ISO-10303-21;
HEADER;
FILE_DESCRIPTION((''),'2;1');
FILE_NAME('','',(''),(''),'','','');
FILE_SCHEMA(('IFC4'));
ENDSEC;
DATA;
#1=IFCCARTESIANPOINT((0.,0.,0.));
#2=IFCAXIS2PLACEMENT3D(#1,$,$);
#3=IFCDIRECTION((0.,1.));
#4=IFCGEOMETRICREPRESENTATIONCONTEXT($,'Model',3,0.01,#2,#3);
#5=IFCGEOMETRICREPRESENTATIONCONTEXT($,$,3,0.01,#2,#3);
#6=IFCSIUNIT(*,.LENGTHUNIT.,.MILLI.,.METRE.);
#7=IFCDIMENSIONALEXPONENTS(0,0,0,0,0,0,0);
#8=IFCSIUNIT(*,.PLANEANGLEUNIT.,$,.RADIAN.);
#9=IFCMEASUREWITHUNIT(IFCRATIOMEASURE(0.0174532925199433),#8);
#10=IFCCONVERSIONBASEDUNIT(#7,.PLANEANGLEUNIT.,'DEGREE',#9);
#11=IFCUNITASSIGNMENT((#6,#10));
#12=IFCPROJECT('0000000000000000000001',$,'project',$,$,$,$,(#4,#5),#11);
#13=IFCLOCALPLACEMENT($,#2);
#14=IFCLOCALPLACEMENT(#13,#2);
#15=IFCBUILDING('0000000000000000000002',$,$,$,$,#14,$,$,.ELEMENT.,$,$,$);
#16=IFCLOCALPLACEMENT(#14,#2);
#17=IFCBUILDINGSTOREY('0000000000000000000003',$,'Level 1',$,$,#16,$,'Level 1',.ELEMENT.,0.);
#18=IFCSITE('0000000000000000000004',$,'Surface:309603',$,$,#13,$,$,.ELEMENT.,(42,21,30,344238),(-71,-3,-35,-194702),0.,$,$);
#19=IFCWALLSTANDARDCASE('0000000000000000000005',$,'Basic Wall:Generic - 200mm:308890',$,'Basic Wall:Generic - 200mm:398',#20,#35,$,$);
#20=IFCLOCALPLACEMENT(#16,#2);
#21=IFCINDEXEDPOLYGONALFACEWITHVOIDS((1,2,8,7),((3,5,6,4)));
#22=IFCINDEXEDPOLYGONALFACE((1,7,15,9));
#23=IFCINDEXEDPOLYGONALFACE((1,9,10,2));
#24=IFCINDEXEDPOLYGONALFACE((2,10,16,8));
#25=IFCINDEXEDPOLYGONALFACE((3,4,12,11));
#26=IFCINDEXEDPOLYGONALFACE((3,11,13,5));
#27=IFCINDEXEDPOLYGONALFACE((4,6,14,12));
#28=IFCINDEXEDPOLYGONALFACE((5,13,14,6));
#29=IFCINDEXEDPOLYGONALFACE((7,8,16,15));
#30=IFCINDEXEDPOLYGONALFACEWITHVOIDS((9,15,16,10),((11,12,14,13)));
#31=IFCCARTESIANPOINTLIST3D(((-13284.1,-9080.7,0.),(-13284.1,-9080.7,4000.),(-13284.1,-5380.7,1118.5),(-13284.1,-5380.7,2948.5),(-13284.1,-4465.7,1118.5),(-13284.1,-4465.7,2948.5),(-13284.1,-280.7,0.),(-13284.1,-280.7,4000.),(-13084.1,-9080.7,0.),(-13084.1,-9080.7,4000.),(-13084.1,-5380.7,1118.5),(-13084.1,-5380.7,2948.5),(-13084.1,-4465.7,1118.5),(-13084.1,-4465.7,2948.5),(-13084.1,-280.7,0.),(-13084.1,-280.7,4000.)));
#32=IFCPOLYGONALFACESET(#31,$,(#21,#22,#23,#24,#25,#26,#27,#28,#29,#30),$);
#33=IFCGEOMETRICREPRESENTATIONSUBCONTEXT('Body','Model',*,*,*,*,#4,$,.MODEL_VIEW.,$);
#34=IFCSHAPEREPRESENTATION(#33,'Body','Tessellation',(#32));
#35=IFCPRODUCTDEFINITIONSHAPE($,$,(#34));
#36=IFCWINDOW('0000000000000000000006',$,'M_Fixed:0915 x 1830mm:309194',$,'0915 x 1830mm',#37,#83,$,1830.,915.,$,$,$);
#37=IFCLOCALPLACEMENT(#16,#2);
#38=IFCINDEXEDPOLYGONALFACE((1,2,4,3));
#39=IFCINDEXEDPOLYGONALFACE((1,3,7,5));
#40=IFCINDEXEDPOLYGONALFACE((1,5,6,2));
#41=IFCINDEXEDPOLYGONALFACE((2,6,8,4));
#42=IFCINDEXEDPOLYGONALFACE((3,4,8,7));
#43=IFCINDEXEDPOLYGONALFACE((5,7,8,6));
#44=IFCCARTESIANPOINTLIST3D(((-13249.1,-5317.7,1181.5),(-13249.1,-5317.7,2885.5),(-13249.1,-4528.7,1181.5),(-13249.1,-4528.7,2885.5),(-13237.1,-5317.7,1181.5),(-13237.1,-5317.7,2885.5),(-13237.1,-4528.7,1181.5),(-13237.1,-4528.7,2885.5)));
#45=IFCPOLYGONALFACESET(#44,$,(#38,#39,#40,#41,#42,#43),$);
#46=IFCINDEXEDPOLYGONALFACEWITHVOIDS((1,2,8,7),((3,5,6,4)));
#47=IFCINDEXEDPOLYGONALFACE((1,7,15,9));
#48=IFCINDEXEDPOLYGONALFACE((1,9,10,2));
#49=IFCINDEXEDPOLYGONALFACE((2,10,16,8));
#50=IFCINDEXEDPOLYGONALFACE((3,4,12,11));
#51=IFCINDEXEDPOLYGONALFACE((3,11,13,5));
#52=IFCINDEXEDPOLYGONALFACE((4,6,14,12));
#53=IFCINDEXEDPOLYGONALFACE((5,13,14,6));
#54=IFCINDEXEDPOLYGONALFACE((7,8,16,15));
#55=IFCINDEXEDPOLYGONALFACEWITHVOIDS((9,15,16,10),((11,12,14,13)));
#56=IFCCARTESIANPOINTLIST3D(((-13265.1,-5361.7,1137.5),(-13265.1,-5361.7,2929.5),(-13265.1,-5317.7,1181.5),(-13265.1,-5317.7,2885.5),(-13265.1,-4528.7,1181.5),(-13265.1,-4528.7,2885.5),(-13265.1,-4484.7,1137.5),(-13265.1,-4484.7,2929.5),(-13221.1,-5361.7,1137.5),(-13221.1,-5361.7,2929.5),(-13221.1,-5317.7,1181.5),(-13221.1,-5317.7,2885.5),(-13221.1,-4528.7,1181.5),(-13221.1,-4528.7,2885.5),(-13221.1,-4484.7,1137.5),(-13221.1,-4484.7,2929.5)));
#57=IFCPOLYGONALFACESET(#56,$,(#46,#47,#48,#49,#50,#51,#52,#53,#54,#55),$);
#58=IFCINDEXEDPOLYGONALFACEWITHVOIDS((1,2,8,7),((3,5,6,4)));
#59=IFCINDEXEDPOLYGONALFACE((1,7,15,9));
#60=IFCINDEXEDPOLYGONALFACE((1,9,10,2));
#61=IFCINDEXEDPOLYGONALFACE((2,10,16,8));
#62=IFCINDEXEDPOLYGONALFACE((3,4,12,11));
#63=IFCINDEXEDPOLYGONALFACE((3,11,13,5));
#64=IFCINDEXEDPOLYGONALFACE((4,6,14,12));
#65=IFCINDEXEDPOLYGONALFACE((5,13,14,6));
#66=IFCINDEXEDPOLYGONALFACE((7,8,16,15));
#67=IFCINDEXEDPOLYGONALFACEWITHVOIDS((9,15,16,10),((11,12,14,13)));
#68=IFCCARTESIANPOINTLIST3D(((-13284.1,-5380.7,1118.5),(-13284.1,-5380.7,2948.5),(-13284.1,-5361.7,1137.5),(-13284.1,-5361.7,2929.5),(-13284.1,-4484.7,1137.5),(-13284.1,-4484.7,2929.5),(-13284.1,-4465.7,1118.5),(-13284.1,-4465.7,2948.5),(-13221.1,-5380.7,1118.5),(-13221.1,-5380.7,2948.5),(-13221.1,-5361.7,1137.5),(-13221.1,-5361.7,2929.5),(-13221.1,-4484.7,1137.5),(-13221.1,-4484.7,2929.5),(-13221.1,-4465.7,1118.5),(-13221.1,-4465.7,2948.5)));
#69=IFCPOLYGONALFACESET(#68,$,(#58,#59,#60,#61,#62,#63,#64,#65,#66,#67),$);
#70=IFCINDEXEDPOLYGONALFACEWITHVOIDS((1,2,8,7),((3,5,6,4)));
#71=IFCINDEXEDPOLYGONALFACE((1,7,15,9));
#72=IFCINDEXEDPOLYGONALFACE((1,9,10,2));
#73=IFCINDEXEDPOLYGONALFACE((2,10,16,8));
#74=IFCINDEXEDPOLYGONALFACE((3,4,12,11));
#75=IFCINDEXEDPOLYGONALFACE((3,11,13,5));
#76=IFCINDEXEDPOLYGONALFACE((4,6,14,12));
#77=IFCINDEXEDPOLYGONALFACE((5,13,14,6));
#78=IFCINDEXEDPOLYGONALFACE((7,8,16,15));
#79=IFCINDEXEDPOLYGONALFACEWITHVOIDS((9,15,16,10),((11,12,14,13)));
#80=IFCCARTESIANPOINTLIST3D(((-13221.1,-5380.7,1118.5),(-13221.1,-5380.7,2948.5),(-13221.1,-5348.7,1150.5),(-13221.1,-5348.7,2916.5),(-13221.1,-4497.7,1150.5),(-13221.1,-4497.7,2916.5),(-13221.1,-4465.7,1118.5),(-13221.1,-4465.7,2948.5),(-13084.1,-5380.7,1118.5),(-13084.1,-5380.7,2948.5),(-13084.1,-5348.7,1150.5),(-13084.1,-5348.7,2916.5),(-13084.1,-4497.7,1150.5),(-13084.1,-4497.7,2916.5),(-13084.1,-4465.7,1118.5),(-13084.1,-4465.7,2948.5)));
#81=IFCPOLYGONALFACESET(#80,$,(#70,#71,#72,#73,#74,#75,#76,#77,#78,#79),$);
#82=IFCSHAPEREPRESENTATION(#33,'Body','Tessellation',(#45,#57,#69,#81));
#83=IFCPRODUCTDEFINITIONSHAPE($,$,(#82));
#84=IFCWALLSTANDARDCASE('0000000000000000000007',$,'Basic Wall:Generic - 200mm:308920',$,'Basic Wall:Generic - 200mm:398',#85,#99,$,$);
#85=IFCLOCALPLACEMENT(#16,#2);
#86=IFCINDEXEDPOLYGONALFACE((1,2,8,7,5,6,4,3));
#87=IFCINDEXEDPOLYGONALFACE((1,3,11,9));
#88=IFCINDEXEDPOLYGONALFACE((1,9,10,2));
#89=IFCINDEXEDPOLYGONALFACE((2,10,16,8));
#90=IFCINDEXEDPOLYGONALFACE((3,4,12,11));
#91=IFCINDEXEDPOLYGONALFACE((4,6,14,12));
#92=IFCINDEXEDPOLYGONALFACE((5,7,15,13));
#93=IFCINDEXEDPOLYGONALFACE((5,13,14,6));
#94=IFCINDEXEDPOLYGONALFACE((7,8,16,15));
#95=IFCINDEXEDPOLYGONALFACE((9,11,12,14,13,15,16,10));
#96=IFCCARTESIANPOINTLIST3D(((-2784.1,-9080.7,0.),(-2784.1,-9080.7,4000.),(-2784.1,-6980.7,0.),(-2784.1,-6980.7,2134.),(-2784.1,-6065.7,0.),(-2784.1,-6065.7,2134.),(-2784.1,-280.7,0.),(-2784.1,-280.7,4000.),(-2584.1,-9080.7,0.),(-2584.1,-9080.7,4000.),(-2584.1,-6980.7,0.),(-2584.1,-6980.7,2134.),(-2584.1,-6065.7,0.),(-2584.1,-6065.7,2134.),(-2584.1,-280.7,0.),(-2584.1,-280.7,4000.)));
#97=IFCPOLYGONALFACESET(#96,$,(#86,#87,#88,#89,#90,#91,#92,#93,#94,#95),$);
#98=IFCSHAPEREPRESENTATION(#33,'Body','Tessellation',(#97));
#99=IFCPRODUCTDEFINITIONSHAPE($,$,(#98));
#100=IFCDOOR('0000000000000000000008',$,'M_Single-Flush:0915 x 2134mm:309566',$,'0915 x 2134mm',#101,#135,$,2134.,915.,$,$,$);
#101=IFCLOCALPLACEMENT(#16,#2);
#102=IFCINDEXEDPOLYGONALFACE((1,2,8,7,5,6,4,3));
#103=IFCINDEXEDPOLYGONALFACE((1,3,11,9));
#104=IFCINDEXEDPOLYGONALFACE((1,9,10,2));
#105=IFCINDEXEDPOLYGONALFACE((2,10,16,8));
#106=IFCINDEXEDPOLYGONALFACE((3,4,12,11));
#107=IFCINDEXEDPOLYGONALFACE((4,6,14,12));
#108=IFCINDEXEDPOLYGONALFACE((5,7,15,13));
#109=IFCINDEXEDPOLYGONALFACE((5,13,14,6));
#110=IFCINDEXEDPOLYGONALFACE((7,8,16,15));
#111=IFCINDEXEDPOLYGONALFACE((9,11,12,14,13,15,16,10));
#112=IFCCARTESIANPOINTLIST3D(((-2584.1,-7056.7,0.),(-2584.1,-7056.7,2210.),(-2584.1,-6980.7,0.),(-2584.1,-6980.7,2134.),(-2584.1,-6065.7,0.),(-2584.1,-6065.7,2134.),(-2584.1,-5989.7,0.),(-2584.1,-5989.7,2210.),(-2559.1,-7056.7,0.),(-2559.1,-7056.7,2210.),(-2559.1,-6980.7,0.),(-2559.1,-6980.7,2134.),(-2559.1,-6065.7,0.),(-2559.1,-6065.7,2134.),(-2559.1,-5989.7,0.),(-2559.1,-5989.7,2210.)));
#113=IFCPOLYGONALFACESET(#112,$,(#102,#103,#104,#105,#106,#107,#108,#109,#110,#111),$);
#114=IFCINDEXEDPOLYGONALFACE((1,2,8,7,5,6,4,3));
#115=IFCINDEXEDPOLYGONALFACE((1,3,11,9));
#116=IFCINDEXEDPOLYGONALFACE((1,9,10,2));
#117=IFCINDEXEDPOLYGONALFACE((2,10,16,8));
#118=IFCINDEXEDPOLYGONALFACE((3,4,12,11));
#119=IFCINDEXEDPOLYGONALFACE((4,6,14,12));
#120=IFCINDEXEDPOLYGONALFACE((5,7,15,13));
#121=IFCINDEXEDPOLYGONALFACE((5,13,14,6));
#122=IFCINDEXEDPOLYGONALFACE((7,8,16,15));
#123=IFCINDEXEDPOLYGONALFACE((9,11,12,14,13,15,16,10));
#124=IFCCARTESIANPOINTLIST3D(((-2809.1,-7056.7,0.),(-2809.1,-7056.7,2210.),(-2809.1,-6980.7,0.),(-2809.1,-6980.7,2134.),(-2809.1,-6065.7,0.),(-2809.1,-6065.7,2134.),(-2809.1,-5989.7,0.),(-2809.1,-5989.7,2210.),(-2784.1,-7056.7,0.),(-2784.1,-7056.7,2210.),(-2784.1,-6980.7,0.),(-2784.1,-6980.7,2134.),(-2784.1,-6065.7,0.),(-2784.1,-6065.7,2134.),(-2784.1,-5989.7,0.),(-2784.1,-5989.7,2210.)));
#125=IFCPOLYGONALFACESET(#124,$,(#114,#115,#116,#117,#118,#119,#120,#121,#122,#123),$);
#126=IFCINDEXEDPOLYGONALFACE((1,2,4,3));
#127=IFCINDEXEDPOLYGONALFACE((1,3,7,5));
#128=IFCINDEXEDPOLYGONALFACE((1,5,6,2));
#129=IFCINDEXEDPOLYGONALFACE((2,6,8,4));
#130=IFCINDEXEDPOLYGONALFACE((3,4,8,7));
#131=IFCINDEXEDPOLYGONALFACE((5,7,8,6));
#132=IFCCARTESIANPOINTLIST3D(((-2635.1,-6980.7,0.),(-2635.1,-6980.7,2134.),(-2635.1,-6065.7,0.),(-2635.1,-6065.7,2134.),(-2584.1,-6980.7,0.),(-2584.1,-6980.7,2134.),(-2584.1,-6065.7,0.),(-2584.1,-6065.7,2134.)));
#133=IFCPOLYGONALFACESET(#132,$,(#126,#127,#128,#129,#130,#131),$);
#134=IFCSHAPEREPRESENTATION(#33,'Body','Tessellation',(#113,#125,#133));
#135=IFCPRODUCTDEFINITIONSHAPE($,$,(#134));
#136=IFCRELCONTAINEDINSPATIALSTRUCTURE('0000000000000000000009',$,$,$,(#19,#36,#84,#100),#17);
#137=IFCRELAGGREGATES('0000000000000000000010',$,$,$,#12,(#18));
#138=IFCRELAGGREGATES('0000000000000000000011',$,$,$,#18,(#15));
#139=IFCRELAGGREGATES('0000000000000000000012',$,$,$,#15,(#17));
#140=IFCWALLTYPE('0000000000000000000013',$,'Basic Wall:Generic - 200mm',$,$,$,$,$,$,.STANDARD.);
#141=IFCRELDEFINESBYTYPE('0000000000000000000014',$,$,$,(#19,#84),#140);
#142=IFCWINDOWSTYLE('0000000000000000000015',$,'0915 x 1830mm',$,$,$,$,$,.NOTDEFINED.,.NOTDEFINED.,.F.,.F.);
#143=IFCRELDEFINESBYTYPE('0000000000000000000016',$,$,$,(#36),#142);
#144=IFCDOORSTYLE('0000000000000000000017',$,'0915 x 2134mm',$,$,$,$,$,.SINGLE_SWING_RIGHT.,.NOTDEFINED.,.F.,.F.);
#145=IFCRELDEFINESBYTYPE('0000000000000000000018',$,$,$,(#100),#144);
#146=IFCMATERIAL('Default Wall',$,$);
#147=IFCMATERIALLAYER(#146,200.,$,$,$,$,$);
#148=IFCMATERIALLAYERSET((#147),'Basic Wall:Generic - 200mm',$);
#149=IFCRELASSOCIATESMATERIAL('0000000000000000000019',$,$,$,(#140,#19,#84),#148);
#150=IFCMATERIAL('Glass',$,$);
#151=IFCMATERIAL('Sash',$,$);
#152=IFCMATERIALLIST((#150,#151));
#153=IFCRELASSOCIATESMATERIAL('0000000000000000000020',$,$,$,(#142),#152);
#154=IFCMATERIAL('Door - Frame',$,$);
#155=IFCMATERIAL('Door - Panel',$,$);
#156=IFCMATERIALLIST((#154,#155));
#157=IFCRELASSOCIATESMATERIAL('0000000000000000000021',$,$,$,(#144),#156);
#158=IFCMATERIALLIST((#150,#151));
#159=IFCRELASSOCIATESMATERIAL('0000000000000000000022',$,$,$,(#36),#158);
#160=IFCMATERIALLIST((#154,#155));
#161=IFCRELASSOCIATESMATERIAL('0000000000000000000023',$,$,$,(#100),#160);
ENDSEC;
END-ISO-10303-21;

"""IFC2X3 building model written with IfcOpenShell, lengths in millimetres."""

from ifc_helpers import new_model, entity, si_unit, converted_unit, direction, frame, frame_2d, origin, place, context, subcontext, project, spatial, polyline, rectangle, outline, extrude, source, transform, mapped, material, material_list, layer, layer_set, layer_usage, type_object, type_shapes, element, fill, save


model = new_model("IFC2X3")

# Units and contexts
model_context = context("Model", 3, precision=0.01, world=origin(), true_north=direction((0.0, 1.0)))
context_of_model = context(None, 3, precision=0.01, world=origin(), true_north=direction((0.0, 1.0)))
body_context = subcontext(model_context, "Body", "Model", "MODEL_VIEW")
ifc_project = project(units=[si_unit("LENGTHUNIT", "METRE", prefix="MILLI"), converted_unit("PLANEANGLEUNIT", "DEGREE", entity("IfcRatioMeasure", 0.0174532925199433), si_unit("PLANEANGLEUNIT", "RADIAN"), dimensions=[0, 0, 0, 0, 0, 0, 0])], contexts=[model_context, context_of_model])

# Site, building, storey
site_placement = place(None, origin())
site = spatial("IfcSite", under=ifc_project, at=site_placement, Name="Surface:309603", CompositionType="ELEMENT", RefLatitude=(42, 21, 30, 344238), RefLongitude=(-71, -3, -35, -194702), RefElevation=0.0)
building_placement = place(site_placement, origin())
building = spatial("IfcBuilding", under=site, at=building_placement, CompositionType="ELEMENT")
storey_placement = place(building_placement, origin())
storey = spatial("IfcBuildingStorey", under=building, at=storey_placement, Name="Level 1", LongName="Level 1", CompositionType="ELEMENT", Elevation=0.0)

# Shared definitions
ifc_material_1 = material(Name="Default Wall")
ifc_layer_1 = layer(ifc_material_1, 200.0)
ifc_layer_set_1 = layer_set([ifc_layer_1], Name="Basic Wall:Generic - 200mm")
wall_type = type_object("IfcWallType", Name="Basic Wall:Generic - 200mm", PredefinedType="STANDARD", material=ifc_layer_set_1)
ifc_material_2 = material(Name="Glass")
ifc_material_3 = material(Name="Sash")
ifc_material_list_1 = material_list([ifc_material_2, ifc_material_3])
window_style = type_object("IfcWindowStyle", Name="0915 x 1830mm", ConstructionType="NOTDEFINED", OperationType="NOTDEFINED", ParameterTakesPrecedence=False, Sizeable=False, material=ifc_material_list_1)
shared_shape_1 = source(origin(), body_context, "Body", "SweptSolid", [
    extrude(rectangle(XDim=12.0, YDim=789.0, at=frame_2d((0.0, 0.0), x_axis=(1.0, 0.0))), frame((457.5, 159.0, 63.0), z_axis=(0.0, 0.0, 1.0), x_axis=(0.0, -1.0, 0.0)), (0.0, 0.0, 1.0), 1704.0),
    extrude(outline(polyline([(-438.5, -896.0), (438.5, -896.0), (438.5, 896.0), (-438.5, 896.0), (-438.5, -896.0)]), holes=[polyline([(-394.5, -852.0), (-394.5, 852.0), (394.5, 852.0), (394.5, -852.0), (-394.5, -852.0)])]), frame((457.5, 137.0, 915.0), z_axis=(0.0, 1.0, 0.0), x_axis=(1.0, 0.0, 0.0)), (0.0, 0.0, 1.0), 44.0),
    extrude(outline(polyline([(-457.5, -915.0), (457.5, -915.0), (457.5, 915.0), (-457.5, 915.0), (-457.5, -915.0)]), holes=[polyline([(-438.5, -896.0), (-438.5, 896.0), (438.5, 896.0), (438.5, -896.0), (-438.5, -896.0)])]), frame((457.5, 137.0, 915.0), z_axis=(0.0, 1.0, 0.0), x_axis=(1.0, 0.0, 0.0)), (0.0, 0.0, 1.0), 63.0),
    extrude(outline(polyline([(-457.5, -915.0), (457.5, -915.0), (457.5, 915.0), (-457.5, 915.0), (-457.5, -915.0)]), holes=[polyline([(-425.5, -883.0), (-425.5, 883.0), (425.5, 883.0), (425.5, -883.0), (-425.5, -883.0)])]), frame((457.5, 0.0, 915.0), z_axis=(0.0, 1.0, 0.0), x_axis=(1.0, 0.0, 0.0)), (0.0, 0.0, 1.0), 137.0),
])
type_shapes(window_style, [shared_shape_1])

# Shared definitions
ifc_material_4 = material(Name="Door - Frame")
ifc_material_5 = material(Name="Door - Panel")
ifc_material_list_2 = material_list([ifc_material_4, ifc_material_5])
door_style = type_object("IfcDoorStyle", Name="0915 x 2134mm", ConstructionType="NOTDEFINED", OperationType="SINGLE_SWING_RIGHT", ParameterTakesPrecedence=False, Sizeable=False, material=ifc_material_list_2)
shared_shape_2 = source(origin(), body_context, "Body", "SweptSolid", [
    extrude(outline(polyline([(-533.5, -1124.0), (533.5, -1124.0), (533.5, 1086.0), (457.5, 1086.0), (457.5, -1048.0), (-457.5, -1048.0), (-457.5, 1086.0), (-533.5, 1086.0), (-533.5, -1124.0)])), frame((457.5, 200.0, 1086.0), z_axis=(0.0, 1.0, 0.0), x_axis=(1.0, 0.0, 0.0)), (0.0, 0.0, 1.0), 25.0),
    extrude(outline(polyline([(-1124.0, -533.5), (1086.0, -533.5), (1086.0, -457.5), (-1048.0, -457.5), (-1048.0, 457.5), (1086.0, 457.5), (1086.0, 533.5), (-1124.0, 533.5), (-1124.0, -533.5)])), frame((457.5, -25.0, 1086.0), z_axis=(0.0, 1.0, 0.0), x_axis=(0.0, 0.0, -1.0)), (0.0, 0.0, 1.0), 25.0),
    extrude(rectangle(XDim=51.0, YDim=915.0, at=frame_2d((0.0, 0.0), x_axis=(1.0, 0.0))), frame((457.5, 174.5, 0.0), z_axis=(0.0, 0.0, 1.0), x_axis=(0.0, 1.0, 0.0)), (0.0, 0.0, 1.0), 2134.0),
])
type_shapes(door_style, [shared_shape_2])

# Wall, opening, window
ifc_layer_usage_1 = layer_usage(ifc_layer_set_1, "AXIS2", "NEGATIVE", 100.0)
wall_1_placement = place(storey_placement, frame((-13184.1, -280.7, 0.0), z_axis=(0.0, 0.0, 1.0), x_axis=(0.0, -1.0, 0.0)))
wall_1 = element("IfcWallStandardCase", 1, at=wall_1_placement, inside=storey, type_object=wall_type, material=ifc_layer_usage_1, Name="Basic Wall:Generic - 200mm:308890", ObjectType="Basic Wall:Generic - 200mm:398", context=body_context, shape_type="SweptSolid", body=[
    extrude(rectangle(XDim=8800.0, YDim=200.0, at=frame_2d((4400.0, 0.0), x_axis=(-1.0, 0.0))), origin(), (0.0, 0.0, 1.0), 4000.0),
])
opening_1_placement = place(wall_1_placement, frame((5100.0, 100.0, 1118.5)))
opening_1 = element("IfcOpeningElement", 2, at=opening_1_placement, cuts=wall_1, ObjectType="Opening", context=body_context, shape_type="SweptSolid", body=[
    extrude(rectangle(XDim=1830.0, YDim=915.0, at=frame_2d((915.0, 457.5), x_axis=(1.0, 0.0))), frame((0.0, 0.0, 0.0), z_axis=(0.0, -1.0, 0.0), x_axis=(0.0, 0.0, 1.0)), (0.0, 0.0, 1.0), 200.0),
])
ifc_material_list_3 = material_list([ifc_material_2, ifc_material_3])
window_1_placement = place(opening_1_placement, frame((0.0, 0.0, 0.0), z_axis=(0.0, 0.0, 1.0), x_axis=(-1.0, 0.0, 0.0)))
window_1 = element("IfcWindow", 3, at=window_1_placement, inside=storey, type_object=window_style, material=ifc_material_list_3, Name="M_Fixed:0915 x 1830mm:309194", ObjectType="0915 x 1830mm", OverallHeight=1830.0, OverallWidth=915.0, context=body_context, shape_type="MappedRepresentation", body=[
    mapped(shared_shape_1, transform((0.0, 0.0, 0.0), scale=1.0)),
])
fill(opening_1, window_1)

# Wall, opening, door
ifc_layer_usage_2 = layer_usage(ifc_layer_set_1, "AXIS2", "NEGATIVE", 100.0)
wall_2_placement = place(storey_placement, frame((-2684.1, -9080.7, 0.0), z_axis=(0.0, 0.0, 1.0), x_axis=(0.0, 1.0, 0.0)))
wall_2 = element("IfcWallStandardCase", 4, at=wall_2_placement, inside=storey, type_object=wall_type, material=ifc_layer_usage_2, Name="Basic Wall:Generic - 200mm:308920", ObjectType="Basic Wall:Generic - 200mm:398", context=body_context, shape_type="SweptSolid", body=[
    extrude(rectangle(XDim=8800.0, YDim=200.0, at=frame_2d((4400.0, 0.0), x_axis=(-1.0, 0.0))), origin(), (0.0, 0.0, 1.0), 4000.0),
])
opening_2_placement = place(wall_2_placement, frame((3015.0, 100.0, 0.0)))
opening_2 = element("IfcOpeningElement", 5, at=opening_2_placement, cuts=wall_2, ObjectType="Opening", context=body_context, shape_type="SweptSolid", body=[
    extrude(rectangle(XDim=915.0, YDim=2134.0, at=frame_2d((1067.0, 457.5), x_axis=(0.0, 1.0))), frame((0.0, 0.0, 0.0), z_axis=(0.0, -1.0, 0.0), x_axis=(0.0, 0.0, 1.0)), (0.0, 0.0, 1.0), 200.0),
])
ifc_material_list_4 = material_list([ifc_material_4, ifc_material_5])
door_1_placement = place(opening_2_placement, frame((0.0, 0.0, 0.0), z_axis=(0.0, 0.0, 1.0), x_axis=(-1.0, 0.0, 0.0)))
door_1 = element("IfcDoor", 6, at=door_1_placement, inside=storey, type_object=door_style, material=ifc_material_list_4, Name="M_Single-Flush:0915 x 2134mm:309566", ObjectType="0915 x 2134mm", OverallHeight=2134.0, OverallWidth=915.0, context=body_context, shape_type="MappedRepresentation", body=[
    mapped(shared_shape_2, transform((0.0, 0.0, 0.0), scale=1.0)),
])
fill(opening_2, door_1)

save(model, "model.ifc")
